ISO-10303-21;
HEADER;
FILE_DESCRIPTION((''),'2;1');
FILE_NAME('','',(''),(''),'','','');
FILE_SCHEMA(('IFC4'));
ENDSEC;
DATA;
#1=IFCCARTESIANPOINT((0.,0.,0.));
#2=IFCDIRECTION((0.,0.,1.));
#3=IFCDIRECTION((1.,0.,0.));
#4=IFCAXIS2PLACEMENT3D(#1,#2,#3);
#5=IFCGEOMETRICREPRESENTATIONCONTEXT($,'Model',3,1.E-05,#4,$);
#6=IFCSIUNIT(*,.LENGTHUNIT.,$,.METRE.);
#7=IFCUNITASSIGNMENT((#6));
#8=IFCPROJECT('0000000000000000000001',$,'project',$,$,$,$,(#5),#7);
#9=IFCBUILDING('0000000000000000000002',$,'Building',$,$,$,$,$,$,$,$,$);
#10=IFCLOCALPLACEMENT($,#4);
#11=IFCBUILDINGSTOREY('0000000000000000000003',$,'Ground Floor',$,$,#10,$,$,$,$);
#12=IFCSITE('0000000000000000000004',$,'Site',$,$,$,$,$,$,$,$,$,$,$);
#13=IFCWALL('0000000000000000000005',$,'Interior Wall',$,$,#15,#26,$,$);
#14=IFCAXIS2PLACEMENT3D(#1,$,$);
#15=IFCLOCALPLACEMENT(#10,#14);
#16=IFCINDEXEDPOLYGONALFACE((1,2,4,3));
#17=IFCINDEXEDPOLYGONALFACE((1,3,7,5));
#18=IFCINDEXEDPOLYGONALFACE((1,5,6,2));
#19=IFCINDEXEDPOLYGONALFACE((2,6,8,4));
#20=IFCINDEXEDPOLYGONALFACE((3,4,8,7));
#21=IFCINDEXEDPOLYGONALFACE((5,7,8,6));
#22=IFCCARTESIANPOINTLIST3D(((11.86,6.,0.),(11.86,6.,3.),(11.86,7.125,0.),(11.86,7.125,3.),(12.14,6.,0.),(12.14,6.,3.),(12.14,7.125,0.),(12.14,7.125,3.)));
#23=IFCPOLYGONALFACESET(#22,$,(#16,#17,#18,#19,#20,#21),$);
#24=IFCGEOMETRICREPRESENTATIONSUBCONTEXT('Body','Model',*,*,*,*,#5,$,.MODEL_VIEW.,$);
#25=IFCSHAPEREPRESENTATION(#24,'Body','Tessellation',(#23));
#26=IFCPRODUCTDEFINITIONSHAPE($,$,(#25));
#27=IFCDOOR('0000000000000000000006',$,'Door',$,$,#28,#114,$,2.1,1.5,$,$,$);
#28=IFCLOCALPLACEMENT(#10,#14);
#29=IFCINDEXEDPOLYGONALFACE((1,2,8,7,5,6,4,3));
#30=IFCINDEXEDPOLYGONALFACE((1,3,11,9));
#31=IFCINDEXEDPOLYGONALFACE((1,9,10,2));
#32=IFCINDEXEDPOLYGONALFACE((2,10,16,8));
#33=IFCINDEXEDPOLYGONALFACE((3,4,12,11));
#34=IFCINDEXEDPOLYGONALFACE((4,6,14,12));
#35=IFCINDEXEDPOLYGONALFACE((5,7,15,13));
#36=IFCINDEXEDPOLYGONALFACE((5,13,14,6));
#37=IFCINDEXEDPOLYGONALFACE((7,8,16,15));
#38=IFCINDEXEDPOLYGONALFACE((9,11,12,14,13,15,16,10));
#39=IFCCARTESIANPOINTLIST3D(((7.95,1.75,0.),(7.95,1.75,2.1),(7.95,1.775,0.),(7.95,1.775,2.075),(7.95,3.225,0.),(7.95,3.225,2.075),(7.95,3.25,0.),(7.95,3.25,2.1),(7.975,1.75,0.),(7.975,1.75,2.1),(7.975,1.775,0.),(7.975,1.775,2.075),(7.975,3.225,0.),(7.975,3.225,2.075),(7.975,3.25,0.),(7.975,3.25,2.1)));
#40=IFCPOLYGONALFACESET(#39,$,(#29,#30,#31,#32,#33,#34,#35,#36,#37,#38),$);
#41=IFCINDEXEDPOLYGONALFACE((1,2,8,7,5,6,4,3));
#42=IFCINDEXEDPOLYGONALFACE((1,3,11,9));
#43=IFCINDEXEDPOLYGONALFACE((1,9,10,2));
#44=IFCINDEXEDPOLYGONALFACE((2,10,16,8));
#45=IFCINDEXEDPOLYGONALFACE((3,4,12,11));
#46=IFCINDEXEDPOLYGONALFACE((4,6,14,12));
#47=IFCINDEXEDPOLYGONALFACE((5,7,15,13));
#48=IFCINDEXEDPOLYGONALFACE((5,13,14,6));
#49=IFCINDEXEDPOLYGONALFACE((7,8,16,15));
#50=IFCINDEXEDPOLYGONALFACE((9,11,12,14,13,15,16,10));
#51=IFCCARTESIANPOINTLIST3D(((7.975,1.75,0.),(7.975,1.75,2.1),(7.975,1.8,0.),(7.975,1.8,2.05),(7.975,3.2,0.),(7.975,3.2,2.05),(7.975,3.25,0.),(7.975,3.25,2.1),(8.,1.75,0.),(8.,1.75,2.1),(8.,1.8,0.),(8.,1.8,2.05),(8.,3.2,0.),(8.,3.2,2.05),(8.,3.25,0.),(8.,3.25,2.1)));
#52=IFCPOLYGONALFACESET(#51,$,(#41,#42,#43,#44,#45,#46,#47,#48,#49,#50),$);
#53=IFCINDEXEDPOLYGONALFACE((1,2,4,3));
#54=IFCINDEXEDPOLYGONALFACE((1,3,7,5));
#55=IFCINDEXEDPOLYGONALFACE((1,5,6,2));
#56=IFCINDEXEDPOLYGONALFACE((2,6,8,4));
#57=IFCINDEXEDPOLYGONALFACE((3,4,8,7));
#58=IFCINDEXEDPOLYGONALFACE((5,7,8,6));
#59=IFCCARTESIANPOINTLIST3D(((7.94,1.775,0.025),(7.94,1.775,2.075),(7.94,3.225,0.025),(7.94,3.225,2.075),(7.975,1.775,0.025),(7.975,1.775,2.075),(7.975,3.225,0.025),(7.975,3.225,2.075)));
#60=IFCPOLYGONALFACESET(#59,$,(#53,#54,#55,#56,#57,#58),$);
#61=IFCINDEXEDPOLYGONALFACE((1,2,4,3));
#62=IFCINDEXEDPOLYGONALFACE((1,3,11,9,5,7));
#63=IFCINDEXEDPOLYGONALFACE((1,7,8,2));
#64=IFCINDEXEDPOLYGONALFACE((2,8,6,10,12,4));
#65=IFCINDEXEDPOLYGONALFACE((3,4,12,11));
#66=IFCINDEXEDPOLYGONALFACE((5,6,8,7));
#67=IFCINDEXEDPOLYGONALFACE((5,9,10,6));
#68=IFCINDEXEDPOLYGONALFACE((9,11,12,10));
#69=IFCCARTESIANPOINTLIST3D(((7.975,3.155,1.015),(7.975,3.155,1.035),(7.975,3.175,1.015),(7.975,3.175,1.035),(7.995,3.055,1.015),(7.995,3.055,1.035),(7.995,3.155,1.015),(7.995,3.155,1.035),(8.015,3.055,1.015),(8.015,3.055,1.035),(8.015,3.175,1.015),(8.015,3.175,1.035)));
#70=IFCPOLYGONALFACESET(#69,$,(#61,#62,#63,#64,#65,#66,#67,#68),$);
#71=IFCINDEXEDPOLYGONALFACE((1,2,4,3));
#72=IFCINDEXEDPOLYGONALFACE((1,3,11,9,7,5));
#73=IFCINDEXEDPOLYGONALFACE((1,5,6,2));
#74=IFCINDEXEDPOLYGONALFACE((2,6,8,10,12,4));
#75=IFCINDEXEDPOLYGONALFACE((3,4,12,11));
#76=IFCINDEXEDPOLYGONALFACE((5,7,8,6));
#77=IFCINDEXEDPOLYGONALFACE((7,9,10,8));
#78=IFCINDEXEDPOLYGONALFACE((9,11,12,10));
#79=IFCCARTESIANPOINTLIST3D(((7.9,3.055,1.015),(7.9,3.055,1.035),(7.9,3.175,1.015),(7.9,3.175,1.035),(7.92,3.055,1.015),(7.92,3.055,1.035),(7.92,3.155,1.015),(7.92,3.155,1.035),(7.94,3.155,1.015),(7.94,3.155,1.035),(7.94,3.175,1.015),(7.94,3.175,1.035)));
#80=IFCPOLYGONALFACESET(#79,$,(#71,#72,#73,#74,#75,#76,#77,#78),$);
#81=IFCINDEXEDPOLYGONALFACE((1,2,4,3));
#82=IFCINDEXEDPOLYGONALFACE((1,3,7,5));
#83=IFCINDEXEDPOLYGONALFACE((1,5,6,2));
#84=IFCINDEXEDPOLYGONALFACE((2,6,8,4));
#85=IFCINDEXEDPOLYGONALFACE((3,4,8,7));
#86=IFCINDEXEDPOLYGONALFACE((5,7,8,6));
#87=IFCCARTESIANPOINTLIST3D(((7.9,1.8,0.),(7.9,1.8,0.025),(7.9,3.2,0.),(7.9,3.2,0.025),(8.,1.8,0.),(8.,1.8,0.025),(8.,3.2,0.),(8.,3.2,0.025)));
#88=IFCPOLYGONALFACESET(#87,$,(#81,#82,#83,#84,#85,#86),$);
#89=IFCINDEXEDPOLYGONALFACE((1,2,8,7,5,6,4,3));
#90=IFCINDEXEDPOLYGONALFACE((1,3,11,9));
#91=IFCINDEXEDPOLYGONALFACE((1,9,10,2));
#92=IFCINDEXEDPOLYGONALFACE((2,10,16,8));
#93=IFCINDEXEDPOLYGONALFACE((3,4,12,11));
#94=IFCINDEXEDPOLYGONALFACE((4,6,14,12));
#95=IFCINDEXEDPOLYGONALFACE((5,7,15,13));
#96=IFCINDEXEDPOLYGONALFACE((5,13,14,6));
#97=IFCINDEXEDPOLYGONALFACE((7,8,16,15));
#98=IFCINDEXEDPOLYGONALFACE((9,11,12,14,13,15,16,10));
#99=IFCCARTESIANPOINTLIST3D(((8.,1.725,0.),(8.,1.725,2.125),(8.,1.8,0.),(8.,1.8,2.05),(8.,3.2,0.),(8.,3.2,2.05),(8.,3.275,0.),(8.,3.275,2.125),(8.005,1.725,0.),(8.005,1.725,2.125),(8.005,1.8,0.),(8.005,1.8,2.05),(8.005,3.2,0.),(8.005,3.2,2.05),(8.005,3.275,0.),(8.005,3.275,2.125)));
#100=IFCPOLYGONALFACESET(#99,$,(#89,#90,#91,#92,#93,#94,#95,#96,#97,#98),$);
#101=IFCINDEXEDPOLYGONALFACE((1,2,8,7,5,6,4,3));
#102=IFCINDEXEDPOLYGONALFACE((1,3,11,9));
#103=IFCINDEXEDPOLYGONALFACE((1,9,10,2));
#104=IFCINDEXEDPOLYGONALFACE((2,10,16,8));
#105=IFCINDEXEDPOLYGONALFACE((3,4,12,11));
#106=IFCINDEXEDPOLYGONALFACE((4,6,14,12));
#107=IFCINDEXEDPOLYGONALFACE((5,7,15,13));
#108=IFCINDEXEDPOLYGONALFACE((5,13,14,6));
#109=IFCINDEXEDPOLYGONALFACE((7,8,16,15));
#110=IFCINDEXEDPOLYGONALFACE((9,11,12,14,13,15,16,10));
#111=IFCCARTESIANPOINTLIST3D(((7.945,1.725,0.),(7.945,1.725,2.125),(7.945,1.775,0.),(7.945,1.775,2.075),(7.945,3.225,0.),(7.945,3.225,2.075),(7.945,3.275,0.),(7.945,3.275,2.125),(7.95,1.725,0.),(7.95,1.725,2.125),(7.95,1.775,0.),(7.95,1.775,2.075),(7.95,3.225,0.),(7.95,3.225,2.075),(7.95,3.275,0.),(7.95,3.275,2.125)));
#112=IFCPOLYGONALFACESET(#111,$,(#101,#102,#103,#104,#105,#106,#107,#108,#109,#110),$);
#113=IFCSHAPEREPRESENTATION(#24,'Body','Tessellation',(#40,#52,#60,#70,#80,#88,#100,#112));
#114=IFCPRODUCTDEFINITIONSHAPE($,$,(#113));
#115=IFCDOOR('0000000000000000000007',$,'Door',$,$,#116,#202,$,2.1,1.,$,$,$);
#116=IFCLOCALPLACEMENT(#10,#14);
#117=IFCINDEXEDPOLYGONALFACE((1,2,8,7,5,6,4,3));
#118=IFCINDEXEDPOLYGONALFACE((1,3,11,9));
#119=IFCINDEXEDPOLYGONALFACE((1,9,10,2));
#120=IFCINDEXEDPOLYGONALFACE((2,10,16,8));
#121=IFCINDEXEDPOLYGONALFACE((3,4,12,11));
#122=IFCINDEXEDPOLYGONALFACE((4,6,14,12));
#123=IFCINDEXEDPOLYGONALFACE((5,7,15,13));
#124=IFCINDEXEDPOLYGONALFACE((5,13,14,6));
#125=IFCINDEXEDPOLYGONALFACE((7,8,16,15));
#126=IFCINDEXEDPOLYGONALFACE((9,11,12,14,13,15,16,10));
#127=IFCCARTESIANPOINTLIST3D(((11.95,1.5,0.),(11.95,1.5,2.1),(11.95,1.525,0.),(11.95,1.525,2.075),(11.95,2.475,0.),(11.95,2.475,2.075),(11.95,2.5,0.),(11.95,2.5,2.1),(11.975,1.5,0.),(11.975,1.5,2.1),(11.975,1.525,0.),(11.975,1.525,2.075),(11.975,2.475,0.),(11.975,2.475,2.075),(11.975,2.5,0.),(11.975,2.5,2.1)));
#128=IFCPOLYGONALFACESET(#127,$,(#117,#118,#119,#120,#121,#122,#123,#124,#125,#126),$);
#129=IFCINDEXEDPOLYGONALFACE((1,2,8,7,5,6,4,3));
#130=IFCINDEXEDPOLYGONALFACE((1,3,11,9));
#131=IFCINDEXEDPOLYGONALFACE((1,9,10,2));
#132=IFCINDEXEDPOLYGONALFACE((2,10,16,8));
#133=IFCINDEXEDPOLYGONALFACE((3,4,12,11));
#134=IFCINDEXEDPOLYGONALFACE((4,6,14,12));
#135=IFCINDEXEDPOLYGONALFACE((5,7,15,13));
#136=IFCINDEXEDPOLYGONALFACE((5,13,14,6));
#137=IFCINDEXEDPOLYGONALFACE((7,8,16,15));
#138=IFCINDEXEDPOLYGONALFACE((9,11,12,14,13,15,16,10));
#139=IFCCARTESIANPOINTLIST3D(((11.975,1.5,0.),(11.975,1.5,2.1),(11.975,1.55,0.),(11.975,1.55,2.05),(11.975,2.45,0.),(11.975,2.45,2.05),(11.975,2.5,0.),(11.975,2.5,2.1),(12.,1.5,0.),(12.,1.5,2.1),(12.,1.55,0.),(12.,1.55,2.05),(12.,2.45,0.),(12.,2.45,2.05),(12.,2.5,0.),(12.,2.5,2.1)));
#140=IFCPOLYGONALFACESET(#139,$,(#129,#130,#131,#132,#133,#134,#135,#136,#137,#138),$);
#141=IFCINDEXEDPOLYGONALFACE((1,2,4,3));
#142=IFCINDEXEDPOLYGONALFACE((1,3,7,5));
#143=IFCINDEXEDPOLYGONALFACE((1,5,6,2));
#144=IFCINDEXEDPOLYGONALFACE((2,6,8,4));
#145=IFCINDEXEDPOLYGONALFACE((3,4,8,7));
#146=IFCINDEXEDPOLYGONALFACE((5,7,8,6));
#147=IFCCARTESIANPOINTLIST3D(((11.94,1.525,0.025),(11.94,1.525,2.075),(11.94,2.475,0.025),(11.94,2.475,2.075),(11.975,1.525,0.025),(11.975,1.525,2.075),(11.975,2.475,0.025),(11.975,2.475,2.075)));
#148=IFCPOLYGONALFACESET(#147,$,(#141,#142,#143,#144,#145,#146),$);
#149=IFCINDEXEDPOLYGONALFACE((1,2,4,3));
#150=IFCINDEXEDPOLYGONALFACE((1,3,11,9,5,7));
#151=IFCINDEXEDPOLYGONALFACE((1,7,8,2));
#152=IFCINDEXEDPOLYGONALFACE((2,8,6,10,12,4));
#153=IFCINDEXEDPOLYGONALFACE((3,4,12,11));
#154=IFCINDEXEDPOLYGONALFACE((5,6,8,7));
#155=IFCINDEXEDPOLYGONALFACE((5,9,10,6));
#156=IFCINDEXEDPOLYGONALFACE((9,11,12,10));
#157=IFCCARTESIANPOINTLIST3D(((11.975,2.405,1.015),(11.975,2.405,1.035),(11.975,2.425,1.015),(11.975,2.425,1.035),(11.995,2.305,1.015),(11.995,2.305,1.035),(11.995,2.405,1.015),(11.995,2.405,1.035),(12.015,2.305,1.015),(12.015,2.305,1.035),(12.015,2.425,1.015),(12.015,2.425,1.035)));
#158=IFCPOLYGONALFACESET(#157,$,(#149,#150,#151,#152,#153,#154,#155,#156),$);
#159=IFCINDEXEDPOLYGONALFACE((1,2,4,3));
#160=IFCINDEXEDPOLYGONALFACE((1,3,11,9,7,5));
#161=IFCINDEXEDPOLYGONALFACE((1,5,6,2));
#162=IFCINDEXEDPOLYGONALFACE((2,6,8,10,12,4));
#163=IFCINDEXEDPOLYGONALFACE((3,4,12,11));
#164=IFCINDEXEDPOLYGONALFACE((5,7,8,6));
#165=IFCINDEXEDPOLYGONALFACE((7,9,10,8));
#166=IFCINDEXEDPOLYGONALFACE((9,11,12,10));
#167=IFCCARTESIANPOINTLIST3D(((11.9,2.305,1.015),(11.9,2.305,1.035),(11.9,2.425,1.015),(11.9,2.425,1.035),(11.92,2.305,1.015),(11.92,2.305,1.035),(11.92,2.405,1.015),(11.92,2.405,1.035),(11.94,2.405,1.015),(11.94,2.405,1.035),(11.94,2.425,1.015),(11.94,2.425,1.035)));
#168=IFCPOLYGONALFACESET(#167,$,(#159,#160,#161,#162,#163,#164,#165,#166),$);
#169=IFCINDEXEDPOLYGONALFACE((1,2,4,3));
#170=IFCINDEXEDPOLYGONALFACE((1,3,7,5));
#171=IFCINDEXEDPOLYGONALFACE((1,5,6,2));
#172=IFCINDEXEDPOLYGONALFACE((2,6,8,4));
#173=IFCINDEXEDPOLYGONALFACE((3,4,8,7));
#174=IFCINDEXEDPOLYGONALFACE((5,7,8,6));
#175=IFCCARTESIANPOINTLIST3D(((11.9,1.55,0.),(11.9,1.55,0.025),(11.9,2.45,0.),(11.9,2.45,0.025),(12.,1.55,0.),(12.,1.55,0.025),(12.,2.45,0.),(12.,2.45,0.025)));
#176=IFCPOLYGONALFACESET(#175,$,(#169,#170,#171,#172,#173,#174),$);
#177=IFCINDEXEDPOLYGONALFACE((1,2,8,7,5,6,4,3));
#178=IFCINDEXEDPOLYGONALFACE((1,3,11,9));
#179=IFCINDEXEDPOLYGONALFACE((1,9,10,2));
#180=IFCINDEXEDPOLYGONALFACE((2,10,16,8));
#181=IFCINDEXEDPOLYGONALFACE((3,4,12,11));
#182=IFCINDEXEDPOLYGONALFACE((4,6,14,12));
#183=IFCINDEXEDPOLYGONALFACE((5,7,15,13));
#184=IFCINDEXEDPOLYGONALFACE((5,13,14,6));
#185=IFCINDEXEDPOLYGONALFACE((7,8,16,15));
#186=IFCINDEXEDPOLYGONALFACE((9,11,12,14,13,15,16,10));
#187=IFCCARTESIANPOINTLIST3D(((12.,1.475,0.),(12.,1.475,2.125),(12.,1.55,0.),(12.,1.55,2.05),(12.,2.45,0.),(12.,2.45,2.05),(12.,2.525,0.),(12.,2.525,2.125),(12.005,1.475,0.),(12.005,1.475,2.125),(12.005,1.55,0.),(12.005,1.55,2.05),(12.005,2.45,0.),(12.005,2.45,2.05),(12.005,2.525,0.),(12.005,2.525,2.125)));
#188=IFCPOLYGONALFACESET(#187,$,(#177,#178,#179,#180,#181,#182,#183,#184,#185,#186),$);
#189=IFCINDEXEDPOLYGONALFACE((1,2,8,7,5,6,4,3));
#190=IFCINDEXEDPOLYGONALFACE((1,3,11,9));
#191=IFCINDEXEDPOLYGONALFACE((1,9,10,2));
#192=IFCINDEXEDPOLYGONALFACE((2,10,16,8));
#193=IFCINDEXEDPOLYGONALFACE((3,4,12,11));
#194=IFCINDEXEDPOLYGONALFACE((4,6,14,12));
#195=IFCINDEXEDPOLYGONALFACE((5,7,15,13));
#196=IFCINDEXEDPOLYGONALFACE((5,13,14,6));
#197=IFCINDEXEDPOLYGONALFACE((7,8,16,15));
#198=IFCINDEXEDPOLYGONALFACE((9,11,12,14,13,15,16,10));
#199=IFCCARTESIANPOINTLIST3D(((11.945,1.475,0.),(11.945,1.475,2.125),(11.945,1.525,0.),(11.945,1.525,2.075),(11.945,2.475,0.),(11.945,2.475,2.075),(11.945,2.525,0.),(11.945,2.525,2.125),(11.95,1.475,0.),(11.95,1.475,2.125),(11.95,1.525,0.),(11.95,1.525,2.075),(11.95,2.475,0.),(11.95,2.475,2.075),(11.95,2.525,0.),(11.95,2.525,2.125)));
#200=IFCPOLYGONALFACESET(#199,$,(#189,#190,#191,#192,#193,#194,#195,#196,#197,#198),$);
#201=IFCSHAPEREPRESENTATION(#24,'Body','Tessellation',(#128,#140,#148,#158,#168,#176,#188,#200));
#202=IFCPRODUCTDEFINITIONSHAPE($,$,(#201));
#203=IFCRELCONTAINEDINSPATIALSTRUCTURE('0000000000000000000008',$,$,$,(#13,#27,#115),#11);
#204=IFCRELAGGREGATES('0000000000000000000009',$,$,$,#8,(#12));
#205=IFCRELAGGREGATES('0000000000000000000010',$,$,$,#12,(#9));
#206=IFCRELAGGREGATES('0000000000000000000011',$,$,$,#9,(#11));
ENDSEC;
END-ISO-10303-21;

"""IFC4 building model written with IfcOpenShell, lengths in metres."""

from ifc_helpers import new_model, si_unit, frame, origin_with_axes, place, context, subcontext, project, spatial, line, indexed_curve, outline, extrude, element, save


model = new_model("IFC4")

# Units and contexts
model_context = context("Model", 3, precision=1e-05, world=origin_with_axes())
body_context = subcontext(model_context, "Body", "Model", "MODEL_VIEW")
ifc_project = project(units=[si_unit("LENGTHUNIT", "METRE")], contexts=[model_context])

# Site, building, storey
site = spatial("IfcSite", under=ifc_project, Name="Site")
building = spatial("IfcBuilding", under=site, Name="Building")
storey_placement = place(None, origin_with_axes())
storey = spatial("IfcBuildingStorey", under=building, at=storey_placement, Name="Ground Floor")

# Wall
wall_1_placement = place(storey_placement, frame((12.0, 6.0, 0.0), z_axis=(0.0, 0.0, 1.0), x_axis=(0.0, 1.0, 0.0)))
element("IfcWall", 1, at=wall_1_placement, inside=storey, Name="Interior Wall", context=body_context, shape_type="SweptSolid", body=[
    extrude(outline(indexed_curve([(0.0, 0.0), (0.0, 0.28), (1.125, 0.28), (1.125, 0.0), (0.0, 0.0)], self_intersect=False)), frame((0.0, -0.14, 0.0), z_axis=(0.0, 0.0, 1.0), x_axis=(1.0, 0.0, 0.0)), (0.0, 0.0, 1.0), 3.0),
])

# Doors
door_1_placement = place(storey_placement, frame((8.0, 1.75, 0.0), z_axis=(0.0, 0.0, 1.0), x_axis=(0.0, 1.0, 0.0)))
element("IfcDoor", 2, at=door_1_placement, inside=storey, Name="Door", OverallHeight=2.1, OverallWidth=1.5, context=body_context, shape_type="SweptSolid", body=[
    extrude(outline(indexed_curve([(0.0, 0.0), (0.0, 2.1), (1.5, 2.1), (1.5, 0.0), (1.475, 0.0), (1.475, 2.075), (0.025, 2.075), (0.025, 0.0)], segments=[line(1, 2, 3, 4, 5, 6, 7, 8, 1)])), frame((0.0, 0.025, 0.0), z_axis=(0.0, -1.0, 0.0), x_axis=(1.0, 0.0, 0.0)), (0.0, 0.0, -1.0), 0.025),
    extrude(outline(indexed_curve([(0.0, 0.0), (0.0, 2.1), (1.5, 2.1), (1.5, 0.0), (1.45, 0.0), (1.45, 2.05), (0.05, 2.05), (0.05, 0.0)], segments=[line(1, 2, 3, 4, 5, 6, 7, 8, 1)])), frame((0.0, 0.0, 0.0), z_axis=(0.0, -1.0, 0.0), x_axis=(1.0, 0.0, 0.0)), (0.0, 0.0, -1.0), 0.025),
    extrude(outline(indexed_curve([(0.0, 0.0), (1.45, 0.0), (1.45, 0.035), (0.0, 0.035)], segments=[line(1, 2, 3, 4, 1)])), frame((0.025, 0.025, 0.025), z_axis=(0.0, 0.0, 1.0), x_axis=(1.0, 0.0, 0.0)), (0.0, 0.0, 1.0), 2.05),
    extrude(outline(indexed_curve([(0.0, 0.0), (0.0, -0.04), (-0.12, -0.04), (-0.12, -0.02), (-0.02, -0.02), (-0.02, 0.0)], segments=[line(1, 2, 3, 4, 5, 6, 1)])), frame((1.425, 0.025, 1.015), z_axis=(0.0, 0.0, 1.0), x_axis=(1.0, 0.0, 0.0)), (0.0, 0.0, 1.0), 0.02),
    extrude(outline(indexed_curve([(0.0, 0.0), (0.0, 0.04), (-0.12, 0.04), (-0.12, 0.02), (-0.02, 0.02), (-0.02, 0.0)], segments=[line(1, 2, 3, 4, 5, 6, 1)])), frame((1.425, 0.06, 1.015), z_axis=(0.0, 0.0, 1.0), x_axis=(1.0, 0.0, 0.0)), (0.0, 0.0, 1.0), 0.02),
    extrude(outline(indexed_curve([(0.0, 0.0), (1.4, 0.0), (1.4, 0.1), (0.0, 0.1)], segments=[line(1, 2, 3, 4, 1)])), frame((0.05, 0.0, 0.0), z_axis=(0.0, 0.0, 1.0), x_axis=(1.0, 0.0, 0.0)), (0.0, 0.0, 1.0), 0.025),
    extrude(outline(indexed_curve([(0.0, 0.0), (0.0, 2.125), (1.55, 2.125), (1.55, 0.0), (1.475, 0.0), (1.475, 2.05), (0.075, 2.05), (0.075, 0.0)], segments=[line(1, 2, 3, 4, 5, 6, 7, 8, 1)])), frame((-0.025, -0.005, 0.0), z_axis=(0.0, -1.0, 0.0), x_axis=(1.0, 0.0, 0.0)), (0.0, 0.0, -1.0), 0.005),
    extrude(outline(indexed_curve([(0.0, 0.0), (0.0, 2.125), (1.55, 2.125), (1.55, 0.0), (1.5, 0.0), (1.5, 2.075), (0.05, 2.075), (0.05, 0.0)], segments=[line(1, 2, 3, 4, 5, 6, 7, 8, 1)])), frame((-0.025, 0.05, 0.0), z_axis=(0.0, -1.0, 0.0), x_axis=(1.0, 0.0, 0.0)), (0.0, 0.0, -1.0), 0.005),
])
door_2_placement = place(storey_placement, frame((12.0, 1.5, 0.0), z_axis=(0.0, 0.0, 1.0), x_axis=(0.0, 1.0, 0.0)))
element("IfcDoor", 3, at=door_2_placement, inside=storey, Name="Door", OverallHeight=2.1, OverallWidth=1.0, context=body_context, shape_type="SweptSolid", body=[
    extrude(outline(indexed_curve([(0.0, 0.0), (0.0, 2.1), (1.0, 2.1), (1.0, 0.0), (0.975, 0.0), (0.975, 2.075), (0.025, 2.075), (0.025, 0.0)], segments=[line(1, 2, 3, 4, 5, 6, 7, 8, 1)])), frame((0.0, 0.025, 0.0), z_axis=(0.0, -1.0, 0.0), x_axis=(1.0, 0.0, 0.0)), (0.0, 0.0, -1.0), 0.025),
    extrude(outline(indexed_curve([(0.0, 0.0), (0.0, 2.1), (1.0, 2.1), (1.0, 0.0), (0.95, 0.0), (0.95, 2.05), (0.05, 2.05), (0.05, 0.0)], segments=[line(1, 2, 3, 4, 5, 6, 7, 8, 1)])), frame((0.0, 0.0, 0.0), z_axis=(0.0, -1.0, 0.0), x_axis=(1.0, 0.0, 0.0)), (0.0, 0.0, -1.0), 0.025),
    extrude(outline(indexed_curve([(0.0, 0.0), (0.95, 0.0), (0.95, 0.035), (0.0, 0.035)], segments=[line(1, 2, 3, 4, 1)])), frame((0.025, 0.025, 0.025), z_axis=(0.0, 0.0, 1.0), x_axis=(1.0, 0.0, 0.0)), (0.0, 0.0, 1.0), 2.05),
    extrude(outline(indexed_curve([(0.0, 0.0), (0.0, -0.04), (-0.12, -0.04), (-0.12, -0.02), (-0.02, -0.02), (-0.02, 0.0)], segments=[line(1, 2, 3, 4, 5, 6, 1)])), frame((0.925, 0.025, 1.015), z_axis=(0.0, 0.0, 1.0), x_axis=(1.0, 0.0, 0.0)), (0.0, 0.0, 1.0), 0.02),
    extrude(outline(indexed_curve([(0.0, 0.0), (0.0, 0.04), (-0.12, 0.04), (-0.12, 0.02), (-0.02, 0.02), (-0.02, 0.0)], segments=[line(1, 2, 3, 4, 5, 6, 1)])), frame((0.925, 0.06, 1.015), z_axis=(0.0, 0.0, 1.0), x_axis=(1.0, 0.0, 0.0)), (0.0, 0.0, 1.0), 0.02),
    extrude(outline(indexed_curve([(0.0, 0.0), (0.9, 0.0), (0.9, 0.1), (0.0, 0.1)], segments=[line(1, 2, 3, 4, 1)])), frame((0.05, 0.0, 0.0), z_axis=(0.0, 0.0, 1.0), x_axis=(1.0, 0.0, 0.0)), (0.0, 0.0, 1.0), 0.025),
    extrude(outline(indexed_curve([(0.0, 0.0), (0.0, 2.125), (1.05, 2.125), (1.05, 0.0), (0.975, 0.0), (0.975, 2.05), (0.075, 2.05), (0.075, 0.0)], segments=[line(1, 2, 3, 4, 5, 6, 7, 8, 1)])), frame((-0.025, -0.005, 0.0), z_axis=(0.0, -1.0, 0.0), x_axis=(1.0, 0.0, 0.0)), (0.0, 0.0, -1.0), 0.005),
    extrude(outline(indexed_curve([(0.0, 0.0), (0.0, 2.125), (1.05, 2.125), (1.05, 0.0), (1.0, 0.0), (1.0, 2.075), (0.05, 2.075), (0.05, 0.0)], segments=[line(1, 2, 3, 4, 5, 6, 7, 8, 1)])), frame((-0.025, 0.05, 0.0), z_axis=(0.0, -1.0, 0.0), x_axis=(1.0, 0.0, 0.0)), (0.0, 0.0, -1.0), 0.005),
])

save(model, "model.ifc")
